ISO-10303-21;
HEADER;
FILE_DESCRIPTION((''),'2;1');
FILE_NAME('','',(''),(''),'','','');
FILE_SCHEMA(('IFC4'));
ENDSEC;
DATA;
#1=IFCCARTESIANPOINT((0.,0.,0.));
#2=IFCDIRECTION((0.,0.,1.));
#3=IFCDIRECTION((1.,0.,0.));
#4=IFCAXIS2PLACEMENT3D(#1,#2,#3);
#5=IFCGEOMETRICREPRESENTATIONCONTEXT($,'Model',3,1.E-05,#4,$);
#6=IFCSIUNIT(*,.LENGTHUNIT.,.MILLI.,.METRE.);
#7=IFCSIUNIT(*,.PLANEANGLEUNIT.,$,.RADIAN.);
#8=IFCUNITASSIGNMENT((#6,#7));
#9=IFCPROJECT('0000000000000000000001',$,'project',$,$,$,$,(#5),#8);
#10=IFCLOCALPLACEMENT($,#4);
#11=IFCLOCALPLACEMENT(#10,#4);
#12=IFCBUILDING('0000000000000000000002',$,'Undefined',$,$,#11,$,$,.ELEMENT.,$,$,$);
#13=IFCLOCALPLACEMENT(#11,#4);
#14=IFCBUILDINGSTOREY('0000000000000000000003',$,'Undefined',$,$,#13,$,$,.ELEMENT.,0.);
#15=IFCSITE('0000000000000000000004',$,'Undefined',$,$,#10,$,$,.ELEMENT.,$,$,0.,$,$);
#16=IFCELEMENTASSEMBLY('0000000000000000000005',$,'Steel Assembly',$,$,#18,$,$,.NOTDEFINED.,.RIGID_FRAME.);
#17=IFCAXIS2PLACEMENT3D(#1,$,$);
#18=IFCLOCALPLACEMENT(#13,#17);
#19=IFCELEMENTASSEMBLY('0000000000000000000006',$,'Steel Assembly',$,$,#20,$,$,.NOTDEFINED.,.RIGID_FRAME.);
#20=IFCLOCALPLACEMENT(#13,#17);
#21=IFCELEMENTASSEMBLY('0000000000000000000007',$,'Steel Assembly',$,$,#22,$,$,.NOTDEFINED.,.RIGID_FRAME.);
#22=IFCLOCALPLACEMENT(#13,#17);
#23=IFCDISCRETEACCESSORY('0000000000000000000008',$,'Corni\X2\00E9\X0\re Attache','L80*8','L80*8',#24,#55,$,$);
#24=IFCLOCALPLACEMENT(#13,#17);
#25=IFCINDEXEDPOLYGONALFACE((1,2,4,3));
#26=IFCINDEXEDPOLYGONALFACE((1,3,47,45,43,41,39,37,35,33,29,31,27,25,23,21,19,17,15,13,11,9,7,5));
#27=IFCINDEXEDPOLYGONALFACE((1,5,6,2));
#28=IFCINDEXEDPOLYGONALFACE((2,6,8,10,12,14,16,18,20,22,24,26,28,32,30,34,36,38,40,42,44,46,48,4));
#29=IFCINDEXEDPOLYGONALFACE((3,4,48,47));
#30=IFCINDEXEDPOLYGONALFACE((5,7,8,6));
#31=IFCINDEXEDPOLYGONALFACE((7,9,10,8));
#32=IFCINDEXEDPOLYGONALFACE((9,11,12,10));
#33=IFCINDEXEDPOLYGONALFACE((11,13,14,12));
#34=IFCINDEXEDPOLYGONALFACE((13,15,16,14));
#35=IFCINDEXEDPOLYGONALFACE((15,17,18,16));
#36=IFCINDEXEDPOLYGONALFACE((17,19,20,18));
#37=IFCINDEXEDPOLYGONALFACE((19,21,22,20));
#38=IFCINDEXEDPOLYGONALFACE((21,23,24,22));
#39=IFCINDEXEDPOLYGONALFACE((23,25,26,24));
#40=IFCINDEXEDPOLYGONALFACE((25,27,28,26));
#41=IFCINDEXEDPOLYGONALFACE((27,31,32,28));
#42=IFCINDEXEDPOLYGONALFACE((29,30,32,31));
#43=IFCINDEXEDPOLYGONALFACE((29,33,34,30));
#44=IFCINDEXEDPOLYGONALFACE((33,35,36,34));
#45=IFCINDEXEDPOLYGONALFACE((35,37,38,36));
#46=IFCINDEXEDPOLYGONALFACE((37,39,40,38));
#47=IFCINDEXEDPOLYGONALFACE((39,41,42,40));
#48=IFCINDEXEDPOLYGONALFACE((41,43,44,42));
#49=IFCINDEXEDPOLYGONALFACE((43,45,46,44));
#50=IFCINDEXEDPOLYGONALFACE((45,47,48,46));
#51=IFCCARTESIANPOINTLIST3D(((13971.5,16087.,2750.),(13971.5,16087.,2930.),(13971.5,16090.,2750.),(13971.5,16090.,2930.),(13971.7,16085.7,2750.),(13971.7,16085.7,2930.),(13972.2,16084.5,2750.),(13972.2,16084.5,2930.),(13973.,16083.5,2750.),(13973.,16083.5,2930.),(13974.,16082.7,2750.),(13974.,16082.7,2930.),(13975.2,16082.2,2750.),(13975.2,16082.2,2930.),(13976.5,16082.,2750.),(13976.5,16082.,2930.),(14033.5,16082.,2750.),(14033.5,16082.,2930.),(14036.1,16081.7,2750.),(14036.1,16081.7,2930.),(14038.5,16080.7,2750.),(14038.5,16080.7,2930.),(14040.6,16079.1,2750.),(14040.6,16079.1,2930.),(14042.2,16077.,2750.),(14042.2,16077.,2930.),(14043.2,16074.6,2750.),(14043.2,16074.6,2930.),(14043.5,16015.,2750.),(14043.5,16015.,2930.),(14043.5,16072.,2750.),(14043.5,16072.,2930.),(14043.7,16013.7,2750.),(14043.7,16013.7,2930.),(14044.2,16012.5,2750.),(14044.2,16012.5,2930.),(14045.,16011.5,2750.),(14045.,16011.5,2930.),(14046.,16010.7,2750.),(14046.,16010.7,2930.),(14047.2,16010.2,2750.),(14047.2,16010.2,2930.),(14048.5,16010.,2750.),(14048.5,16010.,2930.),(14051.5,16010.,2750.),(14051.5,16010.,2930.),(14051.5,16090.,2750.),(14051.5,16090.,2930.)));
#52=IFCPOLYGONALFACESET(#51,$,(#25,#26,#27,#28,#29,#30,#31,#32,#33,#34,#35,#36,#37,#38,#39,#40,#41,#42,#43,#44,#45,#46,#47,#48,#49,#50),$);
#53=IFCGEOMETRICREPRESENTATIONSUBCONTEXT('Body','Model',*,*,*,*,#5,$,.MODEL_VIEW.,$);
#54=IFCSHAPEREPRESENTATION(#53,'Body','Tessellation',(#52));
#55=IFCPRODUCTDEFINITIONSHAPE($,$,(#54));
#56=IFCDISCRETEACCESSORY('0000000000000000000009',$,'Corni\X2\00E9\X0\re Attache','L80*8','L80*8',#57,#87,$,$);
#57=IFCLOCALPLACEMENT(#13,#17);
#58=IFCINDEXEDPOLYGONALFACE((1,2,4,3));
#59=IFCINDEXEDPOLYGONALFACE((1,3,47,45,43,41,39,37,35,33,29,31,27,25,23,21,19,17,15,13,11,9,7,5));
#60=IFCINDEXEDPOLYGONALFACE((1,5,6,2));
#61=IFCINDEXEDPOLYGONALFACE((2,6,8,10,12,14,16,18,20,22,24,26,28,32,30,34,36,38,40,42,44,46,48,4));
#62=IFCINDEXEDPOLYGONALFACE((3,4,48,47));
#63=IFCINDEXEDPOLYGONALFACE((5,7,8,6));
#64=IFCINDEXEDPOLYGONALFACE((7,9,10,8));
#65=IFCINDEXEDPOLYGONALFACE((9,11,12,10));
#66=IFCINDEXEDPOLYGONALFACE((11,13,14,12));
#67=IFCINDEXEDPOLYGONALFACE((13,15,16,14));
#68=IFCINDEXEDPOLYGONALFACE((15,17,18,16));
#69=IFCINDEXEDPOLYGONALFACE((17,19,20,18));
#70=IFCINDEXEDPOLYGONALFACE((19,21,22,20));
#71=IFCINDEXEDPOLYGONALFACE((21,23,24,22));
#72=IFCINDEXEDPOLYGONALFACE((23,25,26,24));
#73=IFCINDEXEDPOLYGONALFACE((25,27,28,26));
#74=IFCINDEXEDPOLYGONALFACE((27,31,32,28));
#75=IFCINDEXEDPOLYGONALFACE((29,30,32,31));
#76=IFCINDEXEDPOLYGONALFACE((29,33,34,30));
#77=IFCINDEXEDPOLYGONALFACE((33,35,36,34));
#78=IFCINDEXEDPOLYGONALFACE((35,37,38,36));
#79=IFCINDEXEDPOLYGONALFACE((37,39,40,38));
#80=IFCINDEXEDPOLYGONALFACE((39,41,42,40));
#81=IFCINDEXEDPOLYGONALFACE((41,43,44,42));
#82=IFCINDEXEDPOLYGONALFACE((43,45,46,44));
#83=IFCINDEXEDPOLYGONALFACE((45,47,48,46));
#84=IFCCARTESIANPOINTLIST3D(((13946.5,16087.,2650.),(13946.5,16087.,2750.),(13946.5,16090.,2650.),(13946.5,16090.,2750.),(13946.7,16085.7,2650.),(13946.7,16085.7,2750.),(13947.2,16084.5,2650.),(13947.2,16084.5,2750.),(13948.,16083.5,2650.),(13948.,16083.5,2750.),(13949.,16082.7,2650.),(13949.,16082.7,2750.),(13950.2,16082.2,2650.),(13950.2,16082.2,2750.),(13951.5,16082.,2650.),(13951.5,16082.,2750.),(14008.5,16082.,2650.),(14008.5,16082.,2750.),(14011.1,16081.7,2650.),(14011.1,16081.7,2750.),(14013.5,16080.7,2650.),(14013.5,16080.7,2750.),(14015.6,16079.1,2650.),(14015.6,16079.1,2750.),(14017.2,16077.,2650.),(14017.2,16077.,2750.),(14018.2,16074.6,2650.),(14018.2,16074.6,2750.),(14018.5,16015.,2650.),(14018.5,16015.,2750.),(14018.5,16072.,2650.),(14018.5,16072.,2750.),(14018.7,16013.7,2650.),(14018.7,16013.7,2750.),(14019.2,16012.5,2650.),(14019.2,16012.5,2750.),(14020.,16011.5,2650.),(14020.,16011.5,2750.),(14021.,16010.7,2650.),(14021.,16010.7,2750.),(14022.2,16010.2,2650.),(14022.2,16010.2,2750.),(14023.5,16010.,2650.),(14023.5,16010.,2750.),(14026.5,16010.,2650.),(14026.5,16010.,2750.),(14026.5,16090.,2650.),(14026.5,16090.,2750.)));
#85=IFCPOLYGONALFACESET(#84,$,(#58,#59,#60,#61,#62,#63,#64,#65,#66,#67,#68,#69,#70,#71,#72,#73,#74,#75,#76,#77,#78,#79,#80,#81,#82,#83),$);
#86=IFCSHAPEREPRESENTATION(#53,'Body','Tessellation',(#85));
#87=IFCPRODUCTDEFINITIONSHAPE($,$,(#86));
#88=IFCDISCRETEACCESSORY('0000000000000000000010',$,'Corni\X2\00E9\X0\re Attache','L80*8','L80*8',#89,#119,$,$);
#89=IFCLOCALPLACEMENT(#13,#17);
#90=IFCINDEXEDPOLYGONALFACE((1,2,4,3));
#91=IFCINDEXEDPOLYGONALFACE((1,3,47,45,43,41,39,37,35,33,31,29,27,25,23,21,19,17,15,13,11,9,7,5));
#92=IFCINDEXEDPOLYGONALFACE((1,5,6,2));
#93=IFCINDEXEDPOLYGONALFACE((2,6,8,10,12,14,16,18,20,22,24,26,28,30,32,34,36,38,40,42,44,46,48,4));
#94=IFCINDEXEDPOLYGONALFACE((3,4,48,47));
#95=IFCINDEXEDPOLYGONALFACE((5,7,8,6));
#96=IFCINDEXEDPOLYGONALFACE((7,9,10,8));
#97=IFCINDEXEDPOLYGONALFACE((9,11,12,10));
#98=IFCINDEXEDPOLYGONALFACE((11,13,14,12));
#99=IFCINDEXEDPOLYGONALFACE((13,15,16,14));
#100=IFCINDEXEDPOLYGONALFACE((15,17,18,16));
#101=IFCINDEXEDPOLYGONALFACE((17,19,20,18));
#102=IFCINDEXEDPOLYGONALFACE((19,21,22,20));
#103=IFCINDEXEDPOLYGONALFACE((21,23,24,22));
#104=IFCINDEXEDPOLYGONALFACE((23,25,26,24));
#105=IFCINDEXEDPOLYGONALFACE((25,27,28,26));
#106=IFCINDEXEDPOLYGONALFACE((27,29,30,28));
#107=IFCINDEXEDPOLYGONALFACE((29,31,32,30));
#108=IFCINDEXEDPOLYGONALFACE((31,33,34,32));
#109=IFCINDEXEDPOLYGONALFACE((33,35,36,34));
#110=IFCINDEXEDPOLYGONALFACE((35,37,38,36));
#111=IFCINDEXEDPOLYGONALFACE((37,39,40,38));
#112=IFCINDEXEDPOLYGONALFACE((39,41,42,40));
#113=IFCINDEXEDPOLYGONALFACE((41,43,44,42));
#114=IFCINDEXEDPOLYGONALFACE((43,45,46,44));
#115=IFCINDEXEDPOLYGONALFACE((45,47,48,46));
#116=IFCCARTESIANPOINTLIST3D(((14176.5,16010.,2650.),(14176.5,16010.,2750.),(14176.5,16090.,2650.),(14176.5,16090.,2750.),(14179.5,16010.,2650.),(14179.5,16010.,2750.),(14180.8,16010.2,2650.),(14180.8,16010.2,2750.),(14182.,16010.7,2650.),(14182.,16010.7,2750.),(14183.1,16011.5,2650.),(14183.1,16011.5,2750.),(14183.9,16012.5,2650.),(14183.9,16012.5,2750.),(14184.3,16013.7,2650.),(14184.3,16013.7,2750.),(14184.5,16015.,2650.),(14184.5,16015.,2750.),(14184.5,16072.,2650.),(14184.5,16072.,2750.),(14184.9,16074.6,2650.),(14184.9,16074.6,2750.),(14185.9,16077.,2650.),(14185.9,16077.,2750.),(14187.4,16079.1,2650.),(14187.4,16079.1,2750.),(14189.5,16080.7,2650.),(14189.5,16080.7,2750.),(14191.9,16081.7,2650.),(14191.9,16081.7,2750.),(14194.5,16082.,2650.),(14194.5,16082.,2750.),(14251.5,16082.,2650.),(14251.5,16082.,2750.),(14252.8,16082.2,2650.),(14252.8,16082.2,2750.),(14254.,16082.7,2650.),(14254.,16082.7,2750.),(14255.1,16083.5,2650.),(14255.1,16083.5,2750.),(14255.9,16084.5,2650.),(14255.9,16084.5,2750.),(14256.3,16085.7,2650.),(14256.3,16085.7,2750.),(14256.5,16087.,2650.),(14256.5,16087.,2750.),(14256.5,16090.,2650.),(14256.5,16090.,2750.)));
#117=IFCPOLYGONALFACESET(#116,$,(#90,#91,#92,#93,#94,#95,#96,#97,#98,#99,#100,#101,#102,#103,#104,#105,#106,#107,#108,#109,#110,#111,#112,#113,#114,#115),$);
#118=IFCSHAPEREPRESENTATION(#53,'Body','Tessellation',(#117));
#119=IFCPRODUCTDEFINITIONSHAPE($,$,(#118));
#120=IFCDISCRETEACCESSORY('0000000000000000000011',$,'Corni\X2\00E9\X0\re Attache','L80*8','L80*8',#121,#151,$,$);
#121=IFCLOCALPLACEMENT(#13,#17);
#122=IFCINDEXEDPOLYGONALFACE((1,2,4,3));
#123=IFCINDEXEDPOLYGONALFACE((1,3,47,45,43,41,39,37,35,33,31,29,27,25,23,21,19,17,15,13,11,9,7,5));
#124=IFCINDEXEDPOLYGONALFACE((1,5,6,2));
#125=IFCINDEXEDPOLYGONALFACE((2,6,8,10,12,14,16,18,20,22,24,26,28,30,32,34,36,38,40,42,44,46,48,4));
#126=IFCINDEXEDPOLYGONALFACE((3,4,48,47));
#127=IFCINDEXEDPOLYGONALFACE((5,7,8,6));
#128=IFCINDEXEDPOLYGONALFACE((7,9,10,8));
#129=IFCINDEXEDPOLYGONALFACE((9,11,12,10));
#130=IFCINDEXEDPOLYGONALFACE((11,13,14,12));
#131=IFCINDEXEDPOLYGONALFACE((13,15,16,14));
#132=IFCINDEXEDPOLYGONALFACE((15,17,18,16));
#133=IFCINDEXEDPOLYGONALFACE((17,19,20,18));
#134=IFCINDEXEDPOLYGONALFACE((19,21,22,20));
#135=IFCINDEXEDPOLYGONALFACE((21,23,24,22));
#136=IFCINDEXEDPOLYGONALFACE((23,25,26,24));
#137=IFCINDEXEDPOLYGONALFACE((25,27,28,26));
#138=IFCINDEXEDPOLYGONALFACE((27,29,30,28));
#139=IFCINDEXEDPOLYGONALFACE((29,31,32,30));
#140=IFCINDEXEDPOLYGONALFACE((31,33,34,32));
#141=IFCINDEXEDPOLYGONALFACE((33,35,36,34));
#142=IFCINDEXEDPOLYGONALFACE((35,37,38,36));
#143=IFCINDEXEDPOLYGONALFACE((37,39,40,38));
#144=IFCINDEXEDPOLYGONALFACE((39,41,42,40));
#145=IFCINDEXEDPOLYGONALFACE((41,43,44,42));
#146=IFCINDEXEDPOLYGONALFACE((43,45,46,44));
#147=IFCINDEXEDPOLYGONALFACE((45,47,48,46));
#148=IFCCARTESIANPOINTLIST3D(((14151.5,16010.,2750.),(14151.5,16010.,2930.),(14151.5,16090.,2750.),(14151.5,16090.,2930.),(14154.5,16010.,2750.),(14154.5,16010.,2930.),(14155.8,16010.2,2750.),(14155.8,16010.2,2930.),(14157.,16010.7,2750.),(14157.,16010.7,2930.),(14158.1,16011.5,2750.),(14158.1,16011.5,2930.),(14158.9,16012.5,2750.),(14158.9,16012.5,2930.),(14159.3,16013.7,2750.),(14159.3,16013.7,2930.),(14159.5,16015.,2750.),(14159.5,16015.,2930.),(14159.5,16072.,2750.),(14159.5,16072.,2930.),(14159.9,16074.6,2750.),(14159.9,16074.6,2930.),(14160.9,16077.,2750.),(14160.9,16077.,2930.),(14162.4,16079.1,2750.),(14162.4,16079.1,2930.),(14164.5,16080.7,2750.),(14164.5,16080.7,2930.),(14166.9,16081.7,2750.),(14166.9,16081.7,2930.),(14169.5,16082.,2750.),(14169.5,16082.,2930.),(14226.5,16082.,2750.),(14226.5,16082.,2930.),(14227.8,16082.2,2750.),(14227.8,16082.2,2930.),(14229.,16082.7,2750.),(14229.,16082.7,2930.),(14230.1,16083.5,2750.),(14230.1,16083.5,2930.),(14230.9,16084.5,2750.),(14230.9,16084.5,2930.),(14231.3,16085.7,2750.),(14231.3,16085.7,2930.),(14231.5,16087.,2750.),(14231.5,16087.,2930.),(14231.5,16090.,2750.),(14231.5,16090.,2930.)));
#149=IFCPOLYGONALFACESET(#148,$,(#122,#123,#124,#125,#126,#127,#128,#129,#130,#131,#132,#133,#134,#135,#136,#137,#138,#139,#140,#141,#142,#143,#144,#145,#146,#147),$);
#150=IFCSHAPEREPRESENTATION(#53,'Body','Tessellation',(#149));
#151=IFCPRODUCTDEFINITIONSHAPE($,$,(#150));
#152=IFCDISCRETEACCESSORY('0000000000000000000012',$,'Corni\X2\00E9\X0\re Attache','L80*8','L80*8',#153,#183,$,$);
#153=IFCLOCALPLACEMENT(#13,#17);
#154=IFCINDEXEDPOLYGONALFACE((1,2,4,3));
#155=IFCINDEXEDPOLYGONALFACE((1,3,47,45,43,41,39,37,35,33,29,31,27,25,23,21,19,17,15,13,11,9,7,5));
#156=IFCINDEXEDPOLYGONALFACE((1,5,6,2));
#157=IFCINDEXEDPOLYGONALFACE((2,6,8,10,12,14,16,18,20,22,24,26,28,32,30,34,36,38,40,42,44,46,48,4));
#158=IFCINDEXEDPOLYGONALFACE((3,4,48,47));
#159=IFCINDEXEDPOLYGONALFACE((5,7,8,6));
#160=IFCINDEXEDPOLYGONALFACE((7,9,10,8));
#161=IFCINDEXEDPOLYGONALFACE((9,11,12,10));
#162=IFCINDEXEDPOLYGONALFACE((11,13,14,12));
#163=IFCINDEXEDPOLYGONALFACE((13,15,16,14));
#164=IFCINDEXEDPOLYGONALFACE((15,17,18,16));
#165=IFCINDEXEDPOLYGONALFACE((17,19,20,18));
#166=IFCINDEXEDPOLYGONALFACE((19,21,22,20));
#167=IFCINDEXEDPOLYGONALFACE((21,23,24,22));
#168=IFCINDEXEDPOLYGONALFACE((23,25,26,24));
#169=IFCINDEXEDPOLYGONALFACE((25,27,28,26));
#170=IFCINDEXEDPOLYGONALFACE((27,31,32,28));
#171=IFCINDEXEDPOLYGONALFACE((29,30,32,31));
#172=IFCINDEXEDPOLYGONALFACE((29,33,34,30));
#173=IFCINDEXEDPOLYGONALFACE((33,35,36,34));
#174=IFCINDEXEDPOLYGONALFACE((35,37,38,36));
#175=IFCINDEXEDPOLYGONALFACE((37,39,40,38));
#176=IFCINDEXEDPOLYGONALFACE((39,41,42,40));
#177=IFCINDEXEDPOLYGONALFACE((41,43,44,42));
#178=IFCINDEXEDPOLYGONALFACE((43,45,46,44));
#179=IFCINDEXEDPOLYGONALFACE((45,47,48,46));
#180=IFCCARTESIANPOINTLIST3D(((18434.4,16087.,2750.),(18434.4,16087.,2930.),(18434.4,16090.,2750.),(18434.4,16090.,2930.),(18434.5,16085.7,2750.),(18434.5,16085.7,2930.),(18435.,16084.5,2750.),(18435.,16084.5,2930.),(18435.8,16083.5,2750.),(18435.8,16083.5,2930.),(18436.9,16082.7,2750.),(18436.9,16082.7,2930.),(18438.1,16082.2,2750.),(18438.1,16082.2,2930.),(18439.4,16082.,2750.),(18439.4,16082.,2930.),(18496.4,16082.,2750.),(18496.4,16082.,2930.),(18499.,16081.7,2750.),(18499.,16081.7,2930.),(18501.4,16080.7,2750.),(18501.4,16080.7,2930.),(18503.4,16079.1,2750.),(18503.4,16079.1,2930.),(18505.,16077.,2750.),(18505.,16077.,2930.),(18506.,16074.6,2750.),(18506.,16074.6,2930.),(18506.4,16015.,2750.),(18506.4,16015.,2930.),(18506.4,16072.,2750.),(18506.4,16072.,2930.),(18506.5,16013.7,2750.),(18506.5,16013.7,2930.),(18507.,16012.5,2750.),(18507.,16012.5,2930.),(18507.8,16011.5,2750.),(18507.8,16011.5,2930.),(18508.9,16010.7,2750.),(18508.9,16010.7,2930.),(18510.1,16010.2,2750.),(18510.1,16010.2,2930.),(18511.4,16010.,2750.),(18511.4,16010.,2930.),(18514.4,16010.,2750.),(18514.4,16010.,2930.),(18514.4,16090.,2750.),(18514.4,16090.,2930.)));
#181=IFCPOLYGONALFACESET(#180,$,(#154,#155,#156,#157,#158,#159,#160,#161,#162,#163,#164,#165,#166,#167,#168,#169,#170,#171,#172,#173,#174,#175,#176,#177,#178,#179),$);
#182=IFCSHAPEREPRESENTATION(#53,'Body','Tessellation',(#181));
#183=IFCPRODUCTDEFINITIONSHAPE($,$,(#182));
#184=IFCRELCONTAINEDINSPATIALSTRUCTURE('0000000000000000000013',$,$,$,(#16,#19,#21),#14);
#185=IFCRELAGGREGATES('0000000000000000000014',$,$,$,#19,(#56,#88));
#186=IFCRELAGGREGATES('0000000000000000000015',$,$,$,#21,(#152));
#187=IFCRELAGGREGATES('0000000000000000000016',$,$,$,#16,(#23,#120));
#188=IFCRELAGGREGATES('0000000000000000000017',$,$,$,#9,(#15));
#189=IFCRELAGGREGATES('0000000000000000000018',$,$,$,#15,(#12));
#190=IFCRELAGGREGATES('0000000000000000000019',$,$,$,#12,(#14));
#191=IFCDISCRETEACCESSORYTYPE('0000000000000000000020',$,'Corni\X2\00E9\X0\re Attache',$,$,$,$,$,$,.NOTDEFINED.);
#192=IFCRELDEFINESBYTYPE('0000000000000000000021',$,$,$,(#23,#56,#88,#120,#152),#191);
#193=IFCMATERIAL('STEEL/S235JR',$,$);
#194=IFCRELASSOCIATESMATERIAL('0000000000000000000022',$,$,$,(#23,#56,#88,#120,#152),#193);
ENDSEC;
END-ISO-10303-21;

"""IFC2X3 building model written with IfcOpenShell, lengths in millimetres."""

from ifc_helpers import new_model, si_unit, frame, origin_with_axes, origin_2d_with_axis, place, context, subcontext, project, spatial, l_section, extrude, material, type_object, element, aggregate, save


model = new_model("IFC2X3")

# Units and contexts
model_context = context("Model", 3, precision=1e-05, world=origin_with_axes())
body_context = subcontext(model_context, "Body", "Model", "MODEL_VIEW")
ifc_project = project(units=[si_unit("LENGTHUNIT", "METRE", prefix="MILLI"), si_unit("PLANEANGLEUNIT", "RADIAN")], contexts=[model_context])

# Site, building, storey
site_placement = place(None, origin_with_axes())
site = spatial("IfcSite", under=ifc_project, at=site_placement, Name="Undefined", CompositionType="ELEMENT", RefElevation=0.0)
building_placement = place(site_placement, origin_with_axes())
building = spatial("IfcBuilding", under=site, at=building_placement, Name="Undefined", CompositionType="ELEMENT")
storey_placement = place(building_placement, origin_with_axes())
storey = spatial("IfcBuildingStorey", under=building, at=storey_placement, Name="Undefined", CompositionType="ELEMENT", Elevation=0.0)

# Shared definitions
ifc_material_1 = material(Name="STEEL/S235JR")

# Element assembly
assembly_1_placement = place(storey_placement, origin_with_axes())
assembly_1 = element("IfcElementAssembly", 1, at=assembly_1_placement, inside=storey, Name="Steel Assembly", AssemblyPlace="NOTDEFINED", PredefinedType="RIGID_FRAME")

# Element assemblies
assembly_2_placement = place(storey_placement, origin_with_axes())
assembly_2 = element("IfcElementAssembly", 2, at=assembly_2_placement, inside=storey, Name="Steel Assembly", AssemblyPlace="NOTDEFINED", PredefinedType="RIGID_FRAME")
assembly_3_placement = place(storey_placement, origin_with_axes())
assembly_3 = element("IfcElementAssembly", 3, at=assembly_3_placement, inside=storey, Name="Steel Assembly", AssemblyPlace="NOTDEFINED", PredefinedType="RIGID_FRAME")

# Discrete accessories
discrete_accessory_type_1 = type_object("IfcDiscreteAccessoryType", Name="Corniére Attache")
discrete_accessory_1_placement = place(assembly_1_placement, frame((14011.5, 16050.0, 2930.0), z_axis=(0.0, -1.0, 0.0), x_axis=(0.0, 0.0, -1.0)))
discrete_accessory_1 = element("IfcDiscreteAccessory", 4, at=discrete_accessory_1_placement, type_object=discrete_accessory_type_1, material=ifc_material_1, Name="Corniére Attache", Description="L80*8", ObjectType="L80*8", context=body_context, shape_type="SweptSolid", body=[
    extrude(l_section(Depth=80.0, Width=80.0, Thickness=8.0, FilletRadius=10.0, EdgeRadius=5.0, at=origin_2d_with_axis()), frame((180.0, 0.0, 0.0), z_axis=(-1.0, 0.0, 0.0), x_axis=(0.0, -1.0, 0.0)), (0.0, 0.0, 1.0), 180.0),
])
discrete_accessory_2_placement = place(assembly_2_placement, frame((13986.5, 16050.0, 2750.0), z_axis=(0.0, -1.0, 0.0), x_axis=(0.0, 0.0, -1.0)))
discrete_accessory_2 = element("IfcDiscreteAccessory", 5, at=discrete_accessory_2_placement, type_object=discrete_accessory_type_1, material=ifc_material_1, Name="Corniére Attache", Description="L80*8", ObjectType="L80*8", context=body_context, shape_type="SweptSolid", body=[
    extrude(l_section(Depth=80.0, Width=80.0, Thickness=8.0, FilletRadius=10.0, EdgeRadius=5.0, at=origin_2d_with_axis()), frame((100.0, 0.0, 0.0), z_axis=(-1.0, 0.0, 0.0), x_axis=(0.0, -1.0, 0.0)), (0.0, 0.0, 1.0), 100.0),
])
discrete_accessory_3_placement = place(assembly_2_placement, frame((14216.5, 16050.0, 2650.0), z_axis=(0.0, 0.0, 1.0), x_axis=(1.0, 0.0, 0.0)))
discrete_accessory_3 = element("IfcDiscreteAccessory", 6, at=discrete_accessory_3_placement, type_object=discrete_accessory_type_1, material=ifc_material_1, Name="Corniére Attache", Description="L80*8", ObjectType="L80*8", context=body_context, shape_type="SweptSolid", body=[
    extrude(l_section(Depth=80.0, Width=80.0, Thickness=8.0, FilletRadius=10.0, EdgeRadius=5.0, at=origin_2d_with_axis()), frame((0.0, 0.0, 100.0), z_axis=(0.0, 0.0, -1.0), x_axis=(1.0, 0.0, 0.0)), (0.0, 0.0, 1.0), 100.0),
])
aggregate(assembly_2, [discrete_accessory_2, discrete_accessory_3])
discrete_accessory_4_placement = place(assembly_1_placement, frame((14191.5, 16050.0, 2750.0), z_axis=(0.0, 0.0, 1.0), x_axis=(1.0, 0.0, 0.0)))
discrete_accessory_4 = element("IfcDiscreteAccessory", 7, at=discrete_accessory_4_placement, type_object=discrete_accessory_type_1, material=ifc_material_1, Name="Corniére Attache", Description="L80*8", ObjectType="L80*8", context=body_context, shape_type="SweptSolid", body=[
    extrude(l_section(Depth=80.0, Width=80.0, Thickness=8.0, FilletRadius=10.0, EdgeRadius=5.0, at=origin_2d_with_axis()), frame((0.0, 0.0, 180.0), z_axis=(0.0, 0.0, -1.0), x_axis=(1.0, 0.0, 0.0)), (0.0, 0.0, 1.0), 180.0),
])
discrete_accessory_5_placement = place(assembly_3_placement, frame((18474.4, 16050.0, 2930.0), z_axis=(0.0, -1.0, 0.0), x_axis=(0.0, 0.0, -1.0)))
discrete_accessory_5 = element("IfcDiscreteAccessory", 8, at=discrete_accessory_5_placement, type_object=discrete_accessory_type_1, material=ifc_material_1, Name="Corniére Attache", Description="L80*8", ObjectType="L80*8", context=body_context, shape_type="SweptSolid", body=[
    extrude(l_section(Depth=80.0, Width=80.0, Thickness=8.0, FilletRadius=10.0, EdgeRadius=5.0, at=origin_2d_with_axis()), frame((180.0, 0.0, 0.0), z_axis=(-1.0, 0.0, 0.0), x_axis=(0.0, -1.0, 0.0)), (0.0, 0.0, 1.0), 180.0),
])
aggregate(assembly_3, [discrete_accessory_5])
aggregate(assembly_1, [discrete_accessory_1, discrete_accessory_4])

save(model, "model.ifc")
